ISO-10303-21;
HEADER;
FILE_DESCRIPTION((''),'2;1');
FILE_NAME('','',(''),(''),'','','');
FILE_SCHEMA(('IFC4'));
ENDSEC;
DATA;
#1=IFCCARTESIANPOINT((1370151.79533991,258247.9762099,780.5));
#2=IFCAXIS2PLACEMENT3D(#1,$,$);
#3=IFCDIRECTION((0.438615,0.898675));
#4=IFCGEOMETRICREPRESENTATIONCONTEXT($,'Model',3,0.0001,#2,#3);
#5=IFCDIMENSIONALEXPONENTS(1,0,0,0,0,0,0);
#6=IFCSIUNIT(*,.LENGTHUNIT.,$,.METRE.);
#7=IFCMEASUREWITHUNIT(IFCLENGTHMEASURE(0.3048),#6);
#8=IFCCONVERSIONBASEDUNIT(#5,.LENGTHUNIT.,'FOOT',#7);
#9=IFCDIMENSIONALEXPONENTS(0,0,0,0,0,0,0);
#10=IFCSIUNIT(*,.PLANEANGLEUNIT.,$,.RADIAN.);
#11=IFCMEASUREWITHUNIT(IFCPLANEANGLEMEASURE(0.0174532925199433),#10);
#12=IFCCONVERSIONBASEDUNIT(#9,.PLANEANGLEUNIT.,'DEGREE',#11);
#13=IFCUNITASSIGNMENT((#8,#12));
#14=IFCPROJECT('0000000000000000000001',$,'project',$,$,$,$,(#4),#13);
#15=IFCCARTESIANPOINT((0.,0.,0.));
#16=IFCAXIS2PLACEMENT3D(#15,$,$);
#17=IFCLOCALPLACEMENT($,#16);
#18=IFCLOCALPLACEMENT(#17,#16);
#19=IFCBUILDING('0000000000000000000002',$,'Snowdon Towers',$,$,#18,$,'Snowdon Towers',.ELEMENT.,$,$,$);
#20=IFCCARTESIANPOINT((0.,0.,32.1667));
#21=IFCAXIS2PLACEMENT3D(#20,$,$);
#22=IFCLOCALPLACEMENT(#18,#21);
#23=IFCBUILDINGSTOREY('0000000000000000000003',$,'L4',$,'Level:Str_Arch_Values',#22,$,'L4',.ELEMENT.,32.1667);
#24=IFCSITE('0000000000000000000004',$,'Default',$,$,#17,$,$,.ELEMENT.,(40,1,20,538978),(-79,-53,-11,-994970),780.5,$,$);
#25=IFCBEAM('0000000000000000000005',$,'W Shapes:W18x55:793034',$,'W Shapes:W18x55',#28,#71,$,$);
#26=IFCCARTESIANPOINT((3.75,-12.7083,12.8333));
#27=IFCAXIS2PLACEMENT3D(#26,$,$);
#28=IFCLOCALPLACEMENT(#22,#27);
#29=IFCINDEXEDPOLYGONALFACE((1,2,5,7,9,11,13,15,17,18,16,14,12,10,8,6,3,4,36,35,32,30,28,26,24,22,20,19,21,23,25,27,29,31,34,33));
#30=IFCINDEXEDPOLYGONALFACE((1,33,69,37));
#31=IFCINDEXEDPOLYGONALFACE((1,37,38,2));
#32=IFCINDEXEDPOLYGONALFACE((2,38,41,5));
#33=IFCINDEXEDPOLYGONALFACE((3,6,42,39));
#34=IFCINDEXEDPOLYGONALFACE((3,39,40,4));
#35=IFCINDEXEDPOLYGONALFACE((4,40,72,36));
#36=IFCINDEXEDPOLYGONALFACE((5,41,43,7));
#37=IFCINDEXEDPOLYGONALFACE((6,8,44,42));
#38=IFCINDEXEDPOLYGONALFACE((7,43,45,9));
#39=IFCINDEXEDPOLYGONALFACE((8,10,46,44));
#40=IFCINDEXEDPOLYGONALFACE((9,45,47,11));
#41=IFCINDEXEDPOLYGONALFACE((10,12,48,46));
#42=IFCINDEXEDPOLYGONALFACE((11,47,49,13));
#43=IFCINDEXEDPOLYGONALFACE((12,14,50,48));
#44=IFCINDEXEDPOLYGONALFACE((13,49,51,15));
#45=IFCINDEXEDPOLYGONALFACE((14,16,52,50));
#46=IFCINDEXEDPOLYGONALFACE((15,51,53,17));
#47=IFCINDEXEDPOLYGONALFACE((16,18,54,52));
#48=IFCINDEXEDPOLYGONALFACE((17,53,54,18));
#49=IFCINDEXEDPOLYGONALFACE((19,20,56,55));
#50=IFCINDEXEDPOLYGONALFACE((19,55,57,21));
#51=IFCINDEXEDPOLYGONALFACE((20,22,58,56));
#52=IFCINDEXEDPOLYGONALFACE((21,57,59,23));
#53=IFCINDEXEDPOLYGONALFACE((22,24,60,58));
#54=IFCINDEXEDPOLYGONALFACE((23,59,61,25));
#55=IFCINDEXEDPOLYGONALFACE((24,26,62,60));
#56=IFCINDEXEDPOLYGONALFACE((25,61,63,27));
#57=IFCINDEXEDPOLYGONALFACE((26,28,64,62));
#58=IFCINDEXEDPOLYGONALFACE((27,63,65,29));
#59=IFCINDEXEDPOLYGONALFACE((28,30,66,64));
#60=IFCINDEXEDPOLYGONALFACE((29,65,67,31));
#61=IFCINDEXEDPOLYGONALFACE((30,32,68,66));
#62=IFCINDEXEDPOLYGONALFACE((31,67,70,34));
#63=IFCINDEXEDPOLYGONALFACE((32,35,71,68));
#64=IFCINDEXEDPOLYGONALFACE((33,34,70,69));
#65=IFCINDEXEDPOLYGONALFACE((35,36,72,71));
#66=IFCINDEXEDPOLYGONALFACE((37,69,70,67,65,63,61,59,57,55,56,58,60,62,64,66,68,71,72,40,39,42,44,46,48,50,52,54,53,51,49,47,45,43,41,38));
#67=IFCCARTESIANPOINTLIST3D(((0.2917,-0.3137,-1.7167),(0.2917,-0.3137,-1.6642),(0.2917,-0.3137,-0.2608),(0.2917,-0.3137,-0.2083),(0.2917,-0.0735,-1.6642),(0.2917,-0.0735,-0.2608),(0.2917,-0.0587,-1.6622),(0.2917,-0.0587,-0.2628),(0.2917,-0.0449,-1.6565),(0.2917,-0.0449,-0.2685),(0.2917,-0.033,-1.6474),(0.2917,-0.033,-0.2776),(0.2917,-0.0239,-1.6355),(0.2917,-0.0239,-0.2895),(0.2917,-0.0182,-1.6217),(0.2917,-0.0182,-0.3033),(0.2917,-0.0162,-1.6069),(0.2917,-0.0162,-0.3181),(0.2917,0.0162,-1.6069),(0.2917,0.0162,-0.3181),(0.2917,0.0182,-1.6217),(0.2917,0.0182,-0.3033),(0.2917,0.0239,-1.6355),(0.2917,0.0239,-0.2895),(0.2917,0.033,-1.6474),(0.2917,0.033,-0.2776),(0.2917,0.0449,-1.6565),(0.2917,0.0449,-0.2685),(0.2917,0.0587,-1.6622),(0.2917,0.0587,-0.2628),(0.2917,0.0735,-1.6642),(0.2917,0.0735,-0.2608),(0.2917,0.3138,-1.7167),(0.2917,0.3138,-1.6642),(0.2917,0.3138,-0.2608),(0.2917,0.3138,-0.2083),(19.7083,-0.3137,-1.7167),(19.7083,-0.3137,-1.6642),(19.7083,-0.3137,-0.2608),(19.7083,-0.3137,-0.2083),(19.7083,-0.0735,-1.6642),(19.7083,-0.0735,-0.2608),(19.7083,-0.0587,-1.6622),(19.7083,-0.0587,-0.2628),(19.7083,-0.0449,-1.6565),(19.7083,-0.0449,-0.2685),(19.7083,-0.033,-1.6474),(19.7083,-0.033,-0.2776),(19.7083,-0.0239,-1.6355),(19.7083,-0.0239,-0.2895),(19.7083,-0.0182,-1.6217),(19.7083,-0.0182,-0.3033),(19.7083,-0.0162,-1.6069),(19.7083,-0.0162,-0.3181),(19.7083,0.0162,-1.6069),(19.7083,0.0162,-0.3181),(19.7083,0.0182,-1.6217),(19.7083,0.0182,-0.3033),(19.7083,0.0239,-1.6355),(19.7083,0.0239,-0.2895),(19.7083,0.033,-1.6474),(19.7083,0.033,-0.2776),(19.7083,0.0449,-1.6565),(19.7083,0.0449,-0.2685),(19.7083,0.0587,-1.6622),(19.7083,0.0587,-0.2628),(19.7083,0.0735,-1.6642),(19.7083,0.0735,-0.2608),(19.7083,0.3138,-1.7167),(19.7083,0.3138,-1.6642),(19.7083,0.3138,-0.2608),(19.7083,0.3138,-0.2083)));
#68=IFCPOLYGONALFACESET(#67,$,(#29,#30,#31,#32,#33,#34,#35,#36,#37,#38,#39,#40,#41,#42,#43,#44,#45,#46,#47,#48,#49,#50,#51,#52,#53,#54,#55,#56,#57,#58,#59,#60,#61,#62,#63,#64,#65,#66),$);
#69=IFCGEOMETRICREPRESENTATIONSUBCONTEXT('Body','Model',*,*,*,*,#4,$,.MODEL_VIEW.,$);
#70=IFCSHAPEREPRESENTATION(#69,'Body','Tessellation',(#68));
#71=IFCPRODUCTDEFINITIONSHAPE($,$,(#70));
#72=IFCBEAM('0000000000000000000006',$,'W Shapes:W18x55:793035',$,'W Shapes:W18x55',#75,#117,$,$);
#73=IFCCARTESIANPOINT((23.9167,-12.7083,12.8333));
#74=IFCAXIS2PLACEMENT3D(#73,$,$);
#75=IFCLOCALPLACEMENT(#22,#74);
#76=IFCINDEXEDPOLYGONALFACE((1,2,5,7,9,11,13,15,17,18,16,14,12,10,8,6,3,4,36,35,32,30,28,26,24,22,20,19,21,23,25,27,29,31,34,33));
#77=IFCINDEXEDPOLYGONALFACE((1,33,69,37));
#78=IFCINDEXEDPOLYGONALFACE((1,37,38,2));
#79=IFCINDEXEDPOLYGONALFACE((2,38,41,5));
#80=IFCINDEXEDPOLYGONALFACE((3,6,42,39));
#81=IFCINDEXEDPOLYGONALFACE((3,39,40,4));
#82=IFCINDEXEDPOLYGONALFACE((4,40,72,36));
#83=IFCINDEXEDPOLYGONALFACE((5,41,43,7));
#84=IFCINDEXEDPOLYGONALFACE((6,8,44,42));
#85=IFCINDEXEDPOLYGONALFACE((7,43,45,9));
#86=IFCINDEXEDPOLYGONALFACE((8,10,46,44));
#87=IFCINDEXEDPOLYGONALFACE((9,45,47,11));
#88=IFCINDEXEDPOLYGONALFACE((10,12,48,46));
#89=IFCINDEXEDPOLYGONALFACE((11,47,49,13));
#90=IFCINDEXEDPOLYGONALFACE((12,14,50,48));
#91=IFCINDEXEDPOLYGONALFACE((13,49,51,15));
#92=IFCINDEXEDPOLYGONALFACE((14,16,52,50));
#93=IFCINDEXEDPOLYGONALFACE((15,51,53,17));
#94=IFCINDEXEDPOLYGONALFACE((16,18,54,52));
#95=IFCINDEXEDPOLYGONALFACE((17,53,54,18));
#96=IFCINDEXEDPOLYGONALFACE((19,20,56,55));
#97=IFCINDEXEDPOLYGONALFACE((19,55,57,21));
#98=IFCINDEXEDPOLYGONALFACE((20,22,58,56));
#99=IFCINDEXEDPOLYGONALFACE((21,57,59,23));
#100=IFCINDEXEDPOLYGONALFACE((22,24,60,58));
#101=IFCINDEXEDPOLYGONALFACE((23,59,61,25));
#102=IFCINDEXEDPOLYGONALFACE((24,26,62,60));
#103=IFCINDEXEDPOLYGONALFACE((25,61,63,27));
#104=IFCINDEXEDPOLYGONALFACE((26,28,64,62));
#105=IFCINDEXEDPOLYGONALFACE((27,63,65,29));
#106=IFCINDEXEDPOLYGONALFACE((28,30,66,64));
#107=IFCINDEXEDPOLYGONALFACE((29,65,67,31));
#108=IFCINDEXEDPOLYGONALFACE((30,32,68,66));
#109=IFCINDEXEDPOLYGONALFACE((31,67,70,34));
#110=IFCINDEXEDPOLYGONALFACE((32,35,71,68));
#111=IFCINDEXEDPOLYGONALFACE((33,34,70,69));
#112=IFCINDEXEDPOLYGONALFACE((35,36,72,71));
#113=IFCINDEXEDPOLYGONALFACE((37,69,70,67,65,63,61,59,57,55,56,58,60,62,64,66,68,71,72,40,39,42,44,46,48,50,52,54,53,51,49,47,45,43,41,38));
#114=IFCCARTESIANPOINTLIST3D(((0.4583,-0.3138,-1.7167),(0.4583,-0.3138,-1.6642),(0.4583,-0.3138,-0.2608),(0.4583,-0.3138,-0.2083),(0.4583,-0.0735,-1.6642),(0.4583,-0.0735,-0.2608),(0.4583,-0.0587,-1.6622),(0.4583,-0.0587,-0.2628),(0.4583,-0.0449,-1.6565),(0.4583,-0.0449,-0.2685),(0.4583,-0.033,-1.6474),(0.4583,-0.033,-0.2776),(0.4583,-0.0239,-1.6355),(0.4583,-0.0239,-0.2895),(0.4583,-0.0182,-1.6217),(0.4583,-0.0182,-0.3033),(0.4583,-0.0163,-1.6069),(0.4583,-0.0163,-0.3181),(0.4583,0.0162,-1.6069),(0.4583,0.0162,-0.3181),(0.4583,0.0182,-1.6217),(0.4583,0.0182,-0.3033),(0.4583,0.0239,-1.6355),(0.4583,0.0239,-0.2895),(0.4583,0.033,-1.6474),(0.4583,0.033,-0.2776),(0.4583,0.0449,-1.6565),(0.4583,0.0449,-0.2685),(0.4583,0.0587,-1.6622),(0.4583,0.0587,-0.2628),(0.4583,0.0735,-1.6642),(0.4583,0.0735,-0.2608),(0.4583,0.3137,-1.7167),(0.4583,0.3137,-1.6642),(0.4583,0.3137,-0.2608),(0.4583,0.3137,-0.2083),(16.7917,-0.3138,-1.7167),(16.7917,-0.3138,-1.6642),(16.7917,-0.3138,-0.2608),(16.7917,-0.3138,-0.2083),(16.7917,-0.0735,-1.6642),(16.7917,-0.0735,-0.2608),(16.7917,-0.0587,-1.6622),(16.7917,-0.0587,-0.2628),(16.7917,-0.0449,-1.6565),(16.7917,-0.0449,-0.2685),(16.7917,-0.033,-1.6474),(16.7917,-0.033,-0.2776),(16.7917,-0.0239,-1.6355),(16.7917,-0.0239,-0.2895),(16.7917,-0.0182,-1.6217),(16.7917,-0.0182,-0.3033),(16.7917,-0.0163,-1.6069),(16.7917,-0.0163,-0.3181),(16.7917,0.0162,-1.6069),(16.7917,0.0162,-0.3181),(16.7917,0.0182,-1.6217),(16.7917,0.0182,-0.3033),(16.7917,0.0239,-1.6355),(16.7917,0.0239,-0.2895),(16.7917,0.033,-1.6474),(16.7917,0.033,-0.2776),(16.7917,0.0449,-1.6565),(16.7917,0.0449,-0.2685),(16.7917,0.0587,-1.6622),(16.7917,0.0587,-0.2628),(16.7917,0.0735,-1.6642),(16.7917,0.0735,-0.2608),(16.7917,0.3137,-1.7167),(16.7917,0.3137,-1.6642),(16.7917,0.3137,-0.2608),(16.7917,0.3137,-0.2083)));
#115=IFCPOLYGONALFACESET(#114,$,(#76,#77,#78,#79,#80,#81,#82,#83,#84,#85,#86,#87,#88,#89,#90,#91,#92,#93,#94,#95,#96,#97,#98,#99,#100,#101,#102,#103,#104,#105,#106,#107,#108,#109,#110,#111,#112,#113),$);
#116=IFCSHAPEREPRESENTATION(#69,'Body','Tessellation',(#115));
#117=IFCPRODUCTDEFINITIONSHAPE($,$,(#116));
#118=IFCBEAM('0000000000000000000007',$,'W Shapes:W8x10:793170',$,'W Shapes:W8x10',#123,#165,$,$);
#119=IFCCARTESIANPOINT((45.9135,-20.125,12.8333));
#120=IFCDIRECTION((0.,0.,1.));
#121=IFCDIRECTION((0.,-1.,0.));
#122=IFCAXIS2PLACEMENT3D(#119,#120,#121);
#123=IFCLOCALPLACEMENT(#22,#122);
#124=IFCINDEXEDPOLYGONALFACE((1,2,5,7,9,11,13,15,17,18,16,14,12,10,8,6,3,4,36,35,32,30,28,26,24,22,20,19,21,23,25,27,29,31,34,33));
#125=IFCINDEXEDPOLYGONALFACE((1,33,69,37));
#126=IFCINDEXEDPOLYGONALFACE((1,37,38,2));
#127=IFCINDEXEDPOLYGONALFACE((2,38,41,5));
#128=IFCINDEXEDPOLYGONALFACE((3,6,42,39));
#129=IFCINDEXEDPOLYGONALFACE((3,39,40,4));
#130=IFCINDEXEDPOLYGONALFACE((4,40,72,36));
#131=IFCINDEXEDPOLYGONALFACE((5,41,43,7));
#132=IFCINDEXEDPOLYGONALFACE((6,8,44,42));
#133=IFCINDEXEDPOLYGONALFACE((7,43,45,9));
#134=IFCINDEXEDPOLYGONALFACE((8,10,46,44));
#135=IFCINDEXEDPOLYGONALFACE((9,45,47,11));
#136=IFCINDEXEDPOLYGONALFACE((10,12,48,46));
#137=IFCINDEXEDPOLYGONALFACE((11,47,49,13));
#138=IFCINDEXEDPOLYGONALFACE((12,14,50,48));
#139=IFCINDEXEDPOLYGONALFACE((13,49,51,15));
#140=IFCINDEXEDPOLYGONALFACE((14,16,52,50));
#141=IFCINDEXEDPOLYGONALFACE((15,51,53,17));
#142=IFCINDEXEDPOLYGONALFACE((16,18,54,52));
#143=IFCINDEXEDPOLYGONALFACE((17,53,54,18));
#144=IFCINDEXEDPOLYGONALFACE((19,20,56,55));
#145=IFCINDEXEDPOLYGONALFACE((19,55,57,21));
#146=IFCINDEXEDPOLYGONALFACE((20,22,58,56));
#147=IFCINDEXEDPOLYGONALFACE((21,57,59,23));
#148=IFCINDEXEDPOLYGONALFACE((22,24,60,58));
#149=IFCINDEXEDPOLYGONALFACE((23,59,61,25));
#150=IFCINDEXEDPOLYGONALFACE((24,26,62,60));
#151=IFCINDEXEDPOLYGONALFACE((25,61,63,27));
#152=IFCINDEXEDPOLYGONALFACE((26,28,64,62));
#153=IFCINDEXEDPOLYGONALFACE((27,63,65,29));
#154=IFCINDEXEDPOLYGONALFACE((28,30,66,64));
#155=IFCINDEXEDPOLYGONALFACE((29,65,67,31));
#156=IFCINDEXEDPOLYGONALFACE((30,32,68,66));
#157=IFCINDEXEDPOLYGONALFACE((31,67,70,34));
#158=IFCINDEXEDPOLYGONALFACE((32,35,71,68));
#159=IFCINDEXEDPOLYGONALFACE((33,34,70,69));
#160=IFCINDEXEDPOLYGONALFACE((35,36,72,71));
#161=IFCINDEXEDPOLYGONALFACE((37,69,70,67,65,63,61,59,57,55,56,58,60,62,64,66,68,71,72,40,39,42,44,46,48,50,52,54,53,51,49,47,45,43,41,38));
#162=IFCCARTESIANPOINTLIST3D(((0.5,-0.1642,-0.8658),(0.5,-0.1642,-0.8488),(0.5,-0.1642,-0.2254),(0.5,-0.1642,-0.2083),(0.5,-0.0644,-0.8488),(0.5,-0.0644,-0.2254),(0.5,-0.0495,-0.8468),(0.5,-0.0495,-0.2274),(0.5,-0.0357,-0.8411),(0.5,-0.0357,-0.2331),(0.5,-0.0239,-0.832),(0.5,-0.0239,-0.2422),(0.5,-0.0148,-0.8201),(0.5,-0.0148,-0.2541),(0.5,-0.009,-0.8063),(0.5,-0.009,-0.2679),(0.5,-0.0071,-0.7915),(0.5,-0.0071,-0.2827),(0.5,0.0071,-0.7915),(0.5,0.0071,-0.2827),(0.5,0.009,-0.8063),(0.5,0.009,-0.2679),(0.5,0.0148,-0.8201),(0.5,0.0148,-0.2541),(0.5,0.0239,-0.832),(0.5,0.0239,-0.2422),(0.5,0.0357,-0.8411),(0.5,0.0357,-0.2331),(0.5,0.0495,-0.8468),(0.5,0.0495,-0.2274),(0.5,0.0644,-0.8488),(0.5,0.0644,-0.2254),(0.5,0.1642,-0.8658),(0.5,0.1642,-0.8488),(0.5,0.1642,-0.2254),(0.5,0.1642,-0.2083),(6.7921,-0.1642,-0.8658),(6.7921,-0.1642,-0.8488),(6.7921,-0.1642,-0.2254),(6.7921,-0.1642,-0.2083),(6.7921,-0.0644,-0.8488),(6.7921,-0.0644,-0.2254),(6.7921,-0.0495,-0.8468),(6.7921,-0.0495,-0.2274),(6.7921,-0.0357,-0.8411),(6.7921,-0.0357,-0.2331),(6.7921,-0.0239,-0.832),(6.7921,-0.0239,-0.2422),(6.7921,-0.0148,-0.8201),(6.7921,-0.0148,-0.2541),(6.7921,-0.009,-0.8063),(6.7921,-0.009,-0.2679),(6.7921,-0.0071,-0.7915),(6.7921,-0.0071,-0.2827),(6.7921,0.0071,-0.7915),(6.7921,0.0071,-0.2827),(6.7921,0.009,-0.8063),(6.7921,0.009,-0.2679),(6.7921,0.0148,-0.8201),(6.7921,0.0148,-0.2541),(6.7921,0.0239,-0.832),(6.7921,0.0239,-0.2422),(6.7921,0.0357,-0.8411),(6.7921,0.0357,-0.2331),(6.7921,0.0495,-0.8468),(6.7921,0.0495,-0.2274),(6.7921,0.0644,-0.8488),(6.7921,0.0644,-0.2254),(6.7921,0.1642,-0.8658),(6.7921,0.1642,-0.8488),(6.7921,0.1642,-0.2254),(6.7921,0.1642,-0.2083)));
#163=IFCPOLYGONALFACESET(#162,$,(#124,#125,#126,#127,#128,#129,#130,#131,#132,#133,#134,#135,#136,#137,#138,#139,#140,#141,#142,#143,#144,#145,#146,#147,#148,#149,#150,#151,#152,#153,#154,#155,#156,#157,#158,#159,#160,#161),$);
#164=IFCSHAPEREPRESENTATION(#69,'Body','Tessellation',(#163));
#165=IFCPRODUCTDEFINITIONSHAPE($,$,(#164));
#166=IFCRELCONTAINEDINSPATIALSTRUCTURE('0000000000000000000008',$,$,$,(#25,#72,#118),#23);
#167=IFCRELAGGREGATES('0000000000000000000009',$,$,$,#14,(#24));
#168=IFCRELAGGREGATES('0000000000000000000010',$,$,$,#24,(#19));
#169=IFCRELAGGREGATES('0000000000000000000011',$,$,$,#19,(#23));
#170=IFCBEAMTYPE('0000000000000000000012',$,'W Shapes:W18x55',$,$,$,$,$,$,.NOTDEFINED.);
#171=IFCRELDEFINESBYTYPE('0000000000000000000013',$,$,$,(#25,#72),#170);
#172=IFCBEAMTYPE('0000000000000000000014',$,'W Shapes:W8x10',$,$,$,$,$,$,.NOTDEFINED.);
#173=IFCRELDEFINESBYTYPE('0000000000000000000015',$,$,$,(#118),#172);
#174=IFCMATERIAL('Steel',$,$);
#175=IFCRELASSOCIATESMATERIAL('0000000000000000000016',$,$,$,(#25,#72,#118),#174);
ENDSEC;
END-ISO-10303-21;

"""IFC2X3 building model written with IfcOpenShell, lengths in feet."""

from ifc_helpers import new_model, entity, si_unit, converted_unit, direction, frame, frame_2d, origin, place, context, subcontext, project, spatial, i_section, extrude, material, type_object, element, save


model = new_model("IFC2X3")

# Units and contexts
model_context = context("Model", 3, precision=0.0001, world=frame((1370151.79533991, 258247.9762099, 780.5)), true_north=direction((0.438615, 0.898675)))
body_context = subcontext(model_context, "Body", "Model", "MODEL_VIEW")
ifc_project = project(units=[converted_unit("LENGTHUNIT", "FOOT", entity("IfcLengthMeasure", 0.3048), si_unit("LENGTHUNIT", "METRE"), dimensions=[1, 0, 0, 0, 0, 0, 0]), converted_unit("PLANEANGLEUNIT", "DEGREE", entity("IfcPlaneAngleMeasure", 0.0174532925199433), si_unit("PLANEANGLEUNIT", "RADIAN"), dimensions=[0, 0, 0, 0, 0, 0, 0])], contexts=[model_context])

# Site, building, storey
site_placement = place(None, origin())
site = spatial("IfcSite", under=ifc_project, at=site_placement, Name="Default", CompositionType="ELEMENT", RefLatitude=(40, 1, 20, 538978), RefLongitude=(-79, -53, -11, -994970), RefElevation=780.5)
building_placement = place(site_placement, origin())
building = spatial("IfcBuilding", under=site, at=building_placement, Name="Snowdon Towers", LongName="Snowdon Towers", CompositionType="ELEMENT")
storey_placement = place(building_placement, frame((0.0, 0.0, 32.1667)))
storey = spatial("IfcBuildingStorey", under=building, at=storey_placement, Name="L4", ObjectType="Level:Str_Arch_Values", LongName="L4", CompositionType="ELEMENT", Elevation=32.1667)

# Beams
ifc_material = material(Name="Steel")
beam_type_1 = type_object("IfcBeamType", Name="W Shapes:W18x55", PredefinedType="NOTDEFINED")
beam_1_placement = place(storey_placement, frame((3.75, -12.7083, 12.8333)))
element("IfcBeam", 1, at=beam_1_placement, inside=storey, type_object=beam_type_1, material=ifc_material, Name="W Shapes:W18x55:793034", ObjectType="W Shapes:W18x55", context=body_context, shape_type="SweptSolid", body=[
    extrude(i_section(OverallWidth=0.6275, OverallDepth=1.5083, WebThickness=0.0325, FlangeThickness=0.0525, FilletRadius=0.0573, at=frame_2d((0.0, 0.0), x_axis=(0.0, 1.0))), frame((0.2917, 0.0, -0.9625), z_axis=(1.0, 0.0, 0.0), x_axis=(0.0, 0.0, -1.0)), (0.0, 0.0, 1.0), 19.4167),
])
beam_2_placement = place(storey_placement, frame((23.9167, -12.7083, 12.8333)))
element("IfcBeam", 2, at=beam_2_placement, inside=storey, type_object=beam_type_1, material=ifc_material, Name="W Shapes:W18x55:793035", ObjectType="W Shapes:W18x55", context=body_context, shape_type="SweptSolid", body=[
    extrude(i_section(OverallWidth=0.6275, OverallDepth=1.5083, WebThickness=0.0325, FlangeThickness=0.0525, FilletRadius=0.0573, at=frame_2d((0.0, 0.0), x_axis=(0.0, 1.0))), frame((0.4583, 0.0, -0.9625), z_axis=(1.0, 0.0, 0.0), x_axis=(0.0, 0.0, -1.0)), (0.0, 0.0, 1.0), 16.3333),
])
beam_type_2 = type_object("IfcBeamType", Name="W Shapes:W8x10", PredefinedType="NOTDEFINED")
beam_3_placement = place(storey_placement, frame((45.9135, -20.125, 12.8333), z_axis=(0.0, 0.0, 1.0), x_axis=(0.0, -1.0, 0.0)))
element("IfcBeam", 3, at=beam_3_placement, inside=storey, type_object=beam_type_2, material=ifc_material, Name="W Shapes:W8x10:793170", ObjectType="W Shapes:W8x10", context=body_context, shape_type="SweptSolid", body=[
    extrude(i_section(OverallWidth=0.3283, OverallDepth=0.6575, WebThickness=0.0142, FlangeThickness=0.0171, FilletRadius=0.0573, at=frame_2d((0.0, 0.0), x_axis=(0.0, 1.0))), frame((0.5, 0.0, -0.5371), z_axis=(1.0, 0.0, 0.0), x_axis=(0.0, 0.0, -1.0)), (0.0, 0.0, 1.0), 6.2921),
])

save(model, "model.ifc")
